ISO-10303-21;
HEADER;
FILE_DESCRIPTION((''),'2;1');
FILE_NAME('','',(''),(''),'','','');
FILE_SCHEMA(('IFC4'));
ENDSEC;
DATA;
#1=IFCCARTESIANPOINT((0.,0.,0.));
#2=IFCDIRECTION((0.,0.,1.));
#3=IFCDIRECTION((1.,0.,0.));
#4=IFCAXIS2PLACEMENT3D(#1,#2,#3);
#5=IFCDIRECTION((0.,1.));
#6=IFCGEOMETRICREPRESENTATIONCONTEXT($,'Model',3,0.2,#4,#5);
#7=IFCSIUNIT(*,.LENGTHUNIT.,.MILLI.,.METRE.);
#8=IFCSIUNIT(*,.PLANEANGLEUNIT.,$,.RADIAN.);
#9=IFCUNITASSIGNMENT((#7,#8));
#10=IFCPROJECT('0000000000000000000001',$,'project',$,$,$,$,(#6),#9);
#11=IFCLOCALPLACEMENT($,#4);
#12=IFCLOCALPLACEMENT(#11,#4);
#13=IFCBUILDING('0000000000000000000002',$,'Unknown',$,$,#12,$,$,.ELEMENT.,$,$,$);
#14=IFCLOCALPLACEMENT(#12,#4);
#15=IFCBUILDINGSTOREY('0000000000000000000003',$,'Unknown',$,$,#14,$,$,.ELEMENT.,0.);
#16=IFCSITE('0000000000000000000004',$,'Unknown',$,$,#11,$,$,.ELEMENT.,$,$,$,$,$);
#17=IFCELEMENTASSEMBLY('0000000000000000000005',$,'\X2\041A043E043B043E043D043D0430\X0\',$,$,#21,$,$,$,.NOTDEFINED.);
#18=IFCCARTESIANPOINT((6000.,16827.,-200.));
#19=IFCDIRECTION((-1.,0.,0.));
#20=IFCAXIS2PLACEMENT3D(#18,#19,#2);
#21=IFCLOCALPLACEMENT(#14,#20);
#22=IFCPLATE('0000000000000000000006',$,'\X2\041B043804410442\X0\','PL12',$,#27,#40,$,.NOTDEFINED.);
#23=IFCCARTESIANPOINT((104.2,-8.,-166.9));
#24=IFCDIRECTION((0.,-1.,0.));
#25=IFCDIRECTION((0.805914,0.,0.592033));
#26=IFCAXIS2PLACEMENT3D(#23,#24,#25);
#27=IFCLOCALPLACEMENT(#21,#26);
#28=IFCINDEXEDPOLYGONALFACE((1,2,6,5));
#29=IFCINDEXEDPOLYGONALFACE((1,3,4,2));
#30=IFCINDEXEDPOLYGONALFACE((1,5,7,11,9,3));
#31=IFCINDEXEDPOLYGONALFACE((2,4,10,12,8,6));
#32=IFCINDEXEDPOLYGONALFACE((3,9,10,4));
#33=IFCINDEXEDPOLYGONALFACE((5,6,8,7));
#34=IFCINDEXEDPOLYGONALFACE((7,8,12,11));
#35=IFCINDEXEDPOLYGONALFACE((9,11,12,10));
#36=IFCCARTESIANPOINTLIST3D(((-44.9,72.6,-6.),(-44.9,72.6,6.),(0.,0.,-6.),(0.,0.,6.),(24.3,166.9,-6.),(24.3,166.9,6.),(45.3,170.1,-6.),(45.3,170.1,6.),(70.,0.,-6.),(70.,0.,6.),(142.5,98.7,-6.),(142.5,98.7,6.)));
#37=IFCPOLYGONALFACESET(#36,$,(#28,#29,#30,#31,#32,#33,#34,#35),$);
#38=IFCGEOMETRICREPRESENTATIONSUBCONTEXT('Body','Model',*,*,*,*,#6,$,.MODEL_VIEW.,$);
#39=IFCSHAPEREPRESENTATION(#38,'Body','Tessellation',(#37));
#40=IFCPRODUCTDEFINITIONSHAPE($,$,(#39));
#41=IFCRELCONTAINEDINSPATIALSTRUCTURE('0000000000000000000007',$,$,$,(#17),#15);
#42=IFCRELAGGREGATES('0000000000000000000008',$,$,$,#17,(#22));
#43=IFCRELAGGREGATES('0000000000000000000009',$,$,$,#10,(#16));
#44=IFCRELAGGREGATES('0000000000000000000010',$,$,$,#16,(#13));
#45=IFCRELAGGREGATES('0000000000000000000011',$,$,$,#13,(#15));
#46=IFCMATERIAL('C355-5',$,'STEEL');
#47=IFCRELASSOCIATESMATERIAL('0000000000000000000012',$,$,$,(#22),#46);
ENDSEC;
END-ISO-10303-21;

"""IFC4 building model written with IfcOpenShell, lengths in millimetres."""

from ifc_helpers import new_model, si_unit, direction, frame, origin_with_axes, place, context, subcontext, project, spatial, line, indexed_curve, outline, extrude, material, element, aggregate, save


model = new_model("IFC4")

# Units and contexts
model_context = context("Model", 3, precision=0.2, world=origin_with_axes(), true_north=direction((0.0, 1.0)))
body_context = subcontext(model_context, "Body", "Model", "MODEL_VIEW")
ifc_project = project(units=[si_unit("LENGTHUNIT", "METRE", prefix="MILLI"), si_unit("PLANEANGLEUNIT", "RADIAN")], contexts=[model_context])

# Site, building, storey
site_placement = place(None, origin_with_axes())
site = spatial("IfcSite", under=ifc_project, at=site_placement, Name="Unknown", CompositionType="ELEMENT")
building_placement = place(site_placement, origin_with_axes())
building = spatial("IfcBuilding", under=site, at=building_placement, Name="Unknown", CompositionType="ELEMENT")
storey_placement = place(building_placement, origin_with_axes())
storey = spatial("IfcBuildingStorey", under=building, at=storey_placement, Name="Unknown", CompositionType="ELEMENT", Elevation=0.0)

# Shared definitions
ifc_material_1 = material(Name="C355-5", Category="STEEL")

# Element assembly, plate
assembly_1_placement = place(storey_placement, frame((6000.0, 16827.0, -200.0), z_axis=(-1.0, 0.0, 0.0), x_axis=(0.0, 0.0, 1.0)))
assembly_1 = element("IfcElementAssembly", 1, at=assembly_1_placement, inside=storey, Name="Колонна", PredefinedType="NOTDEFINED")
plate_1_placement = place(assembly_1_placement, frame((104.2, -8.0, -166.9), z_axis=(0.0, -1.0, 0.0), x_axis=(0.805914, 0.0, 0.592033)))
plate_1 = element("IfcPlate", 2, at=plate_1_placement, material=ifc_material_1, Name="Лист", Description="PL12", PredefinedType="NOTDEFINED", context=body_context, shape_type="SolidModel", body=[
    extrude(outline(indexed_curve([(0.0, 0.0), (70.0, 0.0), (142.5, 98.7), (45.3, 170.1), (24.3, 166.9), (-44.9, 72.6)], segments=[line(1, 2, 3, 4, 5, 6, 1)])), frame((0.0, 0.0, 6.0), z_axis=(0.0, 0.0, 1.0), x_axis=(1.0, 0.0, 0.0)), (0.0, 0.0, -1.0), 12.0),
])
aggregate(assembly_1, [plate_1])

save(model, "model.ifc")
